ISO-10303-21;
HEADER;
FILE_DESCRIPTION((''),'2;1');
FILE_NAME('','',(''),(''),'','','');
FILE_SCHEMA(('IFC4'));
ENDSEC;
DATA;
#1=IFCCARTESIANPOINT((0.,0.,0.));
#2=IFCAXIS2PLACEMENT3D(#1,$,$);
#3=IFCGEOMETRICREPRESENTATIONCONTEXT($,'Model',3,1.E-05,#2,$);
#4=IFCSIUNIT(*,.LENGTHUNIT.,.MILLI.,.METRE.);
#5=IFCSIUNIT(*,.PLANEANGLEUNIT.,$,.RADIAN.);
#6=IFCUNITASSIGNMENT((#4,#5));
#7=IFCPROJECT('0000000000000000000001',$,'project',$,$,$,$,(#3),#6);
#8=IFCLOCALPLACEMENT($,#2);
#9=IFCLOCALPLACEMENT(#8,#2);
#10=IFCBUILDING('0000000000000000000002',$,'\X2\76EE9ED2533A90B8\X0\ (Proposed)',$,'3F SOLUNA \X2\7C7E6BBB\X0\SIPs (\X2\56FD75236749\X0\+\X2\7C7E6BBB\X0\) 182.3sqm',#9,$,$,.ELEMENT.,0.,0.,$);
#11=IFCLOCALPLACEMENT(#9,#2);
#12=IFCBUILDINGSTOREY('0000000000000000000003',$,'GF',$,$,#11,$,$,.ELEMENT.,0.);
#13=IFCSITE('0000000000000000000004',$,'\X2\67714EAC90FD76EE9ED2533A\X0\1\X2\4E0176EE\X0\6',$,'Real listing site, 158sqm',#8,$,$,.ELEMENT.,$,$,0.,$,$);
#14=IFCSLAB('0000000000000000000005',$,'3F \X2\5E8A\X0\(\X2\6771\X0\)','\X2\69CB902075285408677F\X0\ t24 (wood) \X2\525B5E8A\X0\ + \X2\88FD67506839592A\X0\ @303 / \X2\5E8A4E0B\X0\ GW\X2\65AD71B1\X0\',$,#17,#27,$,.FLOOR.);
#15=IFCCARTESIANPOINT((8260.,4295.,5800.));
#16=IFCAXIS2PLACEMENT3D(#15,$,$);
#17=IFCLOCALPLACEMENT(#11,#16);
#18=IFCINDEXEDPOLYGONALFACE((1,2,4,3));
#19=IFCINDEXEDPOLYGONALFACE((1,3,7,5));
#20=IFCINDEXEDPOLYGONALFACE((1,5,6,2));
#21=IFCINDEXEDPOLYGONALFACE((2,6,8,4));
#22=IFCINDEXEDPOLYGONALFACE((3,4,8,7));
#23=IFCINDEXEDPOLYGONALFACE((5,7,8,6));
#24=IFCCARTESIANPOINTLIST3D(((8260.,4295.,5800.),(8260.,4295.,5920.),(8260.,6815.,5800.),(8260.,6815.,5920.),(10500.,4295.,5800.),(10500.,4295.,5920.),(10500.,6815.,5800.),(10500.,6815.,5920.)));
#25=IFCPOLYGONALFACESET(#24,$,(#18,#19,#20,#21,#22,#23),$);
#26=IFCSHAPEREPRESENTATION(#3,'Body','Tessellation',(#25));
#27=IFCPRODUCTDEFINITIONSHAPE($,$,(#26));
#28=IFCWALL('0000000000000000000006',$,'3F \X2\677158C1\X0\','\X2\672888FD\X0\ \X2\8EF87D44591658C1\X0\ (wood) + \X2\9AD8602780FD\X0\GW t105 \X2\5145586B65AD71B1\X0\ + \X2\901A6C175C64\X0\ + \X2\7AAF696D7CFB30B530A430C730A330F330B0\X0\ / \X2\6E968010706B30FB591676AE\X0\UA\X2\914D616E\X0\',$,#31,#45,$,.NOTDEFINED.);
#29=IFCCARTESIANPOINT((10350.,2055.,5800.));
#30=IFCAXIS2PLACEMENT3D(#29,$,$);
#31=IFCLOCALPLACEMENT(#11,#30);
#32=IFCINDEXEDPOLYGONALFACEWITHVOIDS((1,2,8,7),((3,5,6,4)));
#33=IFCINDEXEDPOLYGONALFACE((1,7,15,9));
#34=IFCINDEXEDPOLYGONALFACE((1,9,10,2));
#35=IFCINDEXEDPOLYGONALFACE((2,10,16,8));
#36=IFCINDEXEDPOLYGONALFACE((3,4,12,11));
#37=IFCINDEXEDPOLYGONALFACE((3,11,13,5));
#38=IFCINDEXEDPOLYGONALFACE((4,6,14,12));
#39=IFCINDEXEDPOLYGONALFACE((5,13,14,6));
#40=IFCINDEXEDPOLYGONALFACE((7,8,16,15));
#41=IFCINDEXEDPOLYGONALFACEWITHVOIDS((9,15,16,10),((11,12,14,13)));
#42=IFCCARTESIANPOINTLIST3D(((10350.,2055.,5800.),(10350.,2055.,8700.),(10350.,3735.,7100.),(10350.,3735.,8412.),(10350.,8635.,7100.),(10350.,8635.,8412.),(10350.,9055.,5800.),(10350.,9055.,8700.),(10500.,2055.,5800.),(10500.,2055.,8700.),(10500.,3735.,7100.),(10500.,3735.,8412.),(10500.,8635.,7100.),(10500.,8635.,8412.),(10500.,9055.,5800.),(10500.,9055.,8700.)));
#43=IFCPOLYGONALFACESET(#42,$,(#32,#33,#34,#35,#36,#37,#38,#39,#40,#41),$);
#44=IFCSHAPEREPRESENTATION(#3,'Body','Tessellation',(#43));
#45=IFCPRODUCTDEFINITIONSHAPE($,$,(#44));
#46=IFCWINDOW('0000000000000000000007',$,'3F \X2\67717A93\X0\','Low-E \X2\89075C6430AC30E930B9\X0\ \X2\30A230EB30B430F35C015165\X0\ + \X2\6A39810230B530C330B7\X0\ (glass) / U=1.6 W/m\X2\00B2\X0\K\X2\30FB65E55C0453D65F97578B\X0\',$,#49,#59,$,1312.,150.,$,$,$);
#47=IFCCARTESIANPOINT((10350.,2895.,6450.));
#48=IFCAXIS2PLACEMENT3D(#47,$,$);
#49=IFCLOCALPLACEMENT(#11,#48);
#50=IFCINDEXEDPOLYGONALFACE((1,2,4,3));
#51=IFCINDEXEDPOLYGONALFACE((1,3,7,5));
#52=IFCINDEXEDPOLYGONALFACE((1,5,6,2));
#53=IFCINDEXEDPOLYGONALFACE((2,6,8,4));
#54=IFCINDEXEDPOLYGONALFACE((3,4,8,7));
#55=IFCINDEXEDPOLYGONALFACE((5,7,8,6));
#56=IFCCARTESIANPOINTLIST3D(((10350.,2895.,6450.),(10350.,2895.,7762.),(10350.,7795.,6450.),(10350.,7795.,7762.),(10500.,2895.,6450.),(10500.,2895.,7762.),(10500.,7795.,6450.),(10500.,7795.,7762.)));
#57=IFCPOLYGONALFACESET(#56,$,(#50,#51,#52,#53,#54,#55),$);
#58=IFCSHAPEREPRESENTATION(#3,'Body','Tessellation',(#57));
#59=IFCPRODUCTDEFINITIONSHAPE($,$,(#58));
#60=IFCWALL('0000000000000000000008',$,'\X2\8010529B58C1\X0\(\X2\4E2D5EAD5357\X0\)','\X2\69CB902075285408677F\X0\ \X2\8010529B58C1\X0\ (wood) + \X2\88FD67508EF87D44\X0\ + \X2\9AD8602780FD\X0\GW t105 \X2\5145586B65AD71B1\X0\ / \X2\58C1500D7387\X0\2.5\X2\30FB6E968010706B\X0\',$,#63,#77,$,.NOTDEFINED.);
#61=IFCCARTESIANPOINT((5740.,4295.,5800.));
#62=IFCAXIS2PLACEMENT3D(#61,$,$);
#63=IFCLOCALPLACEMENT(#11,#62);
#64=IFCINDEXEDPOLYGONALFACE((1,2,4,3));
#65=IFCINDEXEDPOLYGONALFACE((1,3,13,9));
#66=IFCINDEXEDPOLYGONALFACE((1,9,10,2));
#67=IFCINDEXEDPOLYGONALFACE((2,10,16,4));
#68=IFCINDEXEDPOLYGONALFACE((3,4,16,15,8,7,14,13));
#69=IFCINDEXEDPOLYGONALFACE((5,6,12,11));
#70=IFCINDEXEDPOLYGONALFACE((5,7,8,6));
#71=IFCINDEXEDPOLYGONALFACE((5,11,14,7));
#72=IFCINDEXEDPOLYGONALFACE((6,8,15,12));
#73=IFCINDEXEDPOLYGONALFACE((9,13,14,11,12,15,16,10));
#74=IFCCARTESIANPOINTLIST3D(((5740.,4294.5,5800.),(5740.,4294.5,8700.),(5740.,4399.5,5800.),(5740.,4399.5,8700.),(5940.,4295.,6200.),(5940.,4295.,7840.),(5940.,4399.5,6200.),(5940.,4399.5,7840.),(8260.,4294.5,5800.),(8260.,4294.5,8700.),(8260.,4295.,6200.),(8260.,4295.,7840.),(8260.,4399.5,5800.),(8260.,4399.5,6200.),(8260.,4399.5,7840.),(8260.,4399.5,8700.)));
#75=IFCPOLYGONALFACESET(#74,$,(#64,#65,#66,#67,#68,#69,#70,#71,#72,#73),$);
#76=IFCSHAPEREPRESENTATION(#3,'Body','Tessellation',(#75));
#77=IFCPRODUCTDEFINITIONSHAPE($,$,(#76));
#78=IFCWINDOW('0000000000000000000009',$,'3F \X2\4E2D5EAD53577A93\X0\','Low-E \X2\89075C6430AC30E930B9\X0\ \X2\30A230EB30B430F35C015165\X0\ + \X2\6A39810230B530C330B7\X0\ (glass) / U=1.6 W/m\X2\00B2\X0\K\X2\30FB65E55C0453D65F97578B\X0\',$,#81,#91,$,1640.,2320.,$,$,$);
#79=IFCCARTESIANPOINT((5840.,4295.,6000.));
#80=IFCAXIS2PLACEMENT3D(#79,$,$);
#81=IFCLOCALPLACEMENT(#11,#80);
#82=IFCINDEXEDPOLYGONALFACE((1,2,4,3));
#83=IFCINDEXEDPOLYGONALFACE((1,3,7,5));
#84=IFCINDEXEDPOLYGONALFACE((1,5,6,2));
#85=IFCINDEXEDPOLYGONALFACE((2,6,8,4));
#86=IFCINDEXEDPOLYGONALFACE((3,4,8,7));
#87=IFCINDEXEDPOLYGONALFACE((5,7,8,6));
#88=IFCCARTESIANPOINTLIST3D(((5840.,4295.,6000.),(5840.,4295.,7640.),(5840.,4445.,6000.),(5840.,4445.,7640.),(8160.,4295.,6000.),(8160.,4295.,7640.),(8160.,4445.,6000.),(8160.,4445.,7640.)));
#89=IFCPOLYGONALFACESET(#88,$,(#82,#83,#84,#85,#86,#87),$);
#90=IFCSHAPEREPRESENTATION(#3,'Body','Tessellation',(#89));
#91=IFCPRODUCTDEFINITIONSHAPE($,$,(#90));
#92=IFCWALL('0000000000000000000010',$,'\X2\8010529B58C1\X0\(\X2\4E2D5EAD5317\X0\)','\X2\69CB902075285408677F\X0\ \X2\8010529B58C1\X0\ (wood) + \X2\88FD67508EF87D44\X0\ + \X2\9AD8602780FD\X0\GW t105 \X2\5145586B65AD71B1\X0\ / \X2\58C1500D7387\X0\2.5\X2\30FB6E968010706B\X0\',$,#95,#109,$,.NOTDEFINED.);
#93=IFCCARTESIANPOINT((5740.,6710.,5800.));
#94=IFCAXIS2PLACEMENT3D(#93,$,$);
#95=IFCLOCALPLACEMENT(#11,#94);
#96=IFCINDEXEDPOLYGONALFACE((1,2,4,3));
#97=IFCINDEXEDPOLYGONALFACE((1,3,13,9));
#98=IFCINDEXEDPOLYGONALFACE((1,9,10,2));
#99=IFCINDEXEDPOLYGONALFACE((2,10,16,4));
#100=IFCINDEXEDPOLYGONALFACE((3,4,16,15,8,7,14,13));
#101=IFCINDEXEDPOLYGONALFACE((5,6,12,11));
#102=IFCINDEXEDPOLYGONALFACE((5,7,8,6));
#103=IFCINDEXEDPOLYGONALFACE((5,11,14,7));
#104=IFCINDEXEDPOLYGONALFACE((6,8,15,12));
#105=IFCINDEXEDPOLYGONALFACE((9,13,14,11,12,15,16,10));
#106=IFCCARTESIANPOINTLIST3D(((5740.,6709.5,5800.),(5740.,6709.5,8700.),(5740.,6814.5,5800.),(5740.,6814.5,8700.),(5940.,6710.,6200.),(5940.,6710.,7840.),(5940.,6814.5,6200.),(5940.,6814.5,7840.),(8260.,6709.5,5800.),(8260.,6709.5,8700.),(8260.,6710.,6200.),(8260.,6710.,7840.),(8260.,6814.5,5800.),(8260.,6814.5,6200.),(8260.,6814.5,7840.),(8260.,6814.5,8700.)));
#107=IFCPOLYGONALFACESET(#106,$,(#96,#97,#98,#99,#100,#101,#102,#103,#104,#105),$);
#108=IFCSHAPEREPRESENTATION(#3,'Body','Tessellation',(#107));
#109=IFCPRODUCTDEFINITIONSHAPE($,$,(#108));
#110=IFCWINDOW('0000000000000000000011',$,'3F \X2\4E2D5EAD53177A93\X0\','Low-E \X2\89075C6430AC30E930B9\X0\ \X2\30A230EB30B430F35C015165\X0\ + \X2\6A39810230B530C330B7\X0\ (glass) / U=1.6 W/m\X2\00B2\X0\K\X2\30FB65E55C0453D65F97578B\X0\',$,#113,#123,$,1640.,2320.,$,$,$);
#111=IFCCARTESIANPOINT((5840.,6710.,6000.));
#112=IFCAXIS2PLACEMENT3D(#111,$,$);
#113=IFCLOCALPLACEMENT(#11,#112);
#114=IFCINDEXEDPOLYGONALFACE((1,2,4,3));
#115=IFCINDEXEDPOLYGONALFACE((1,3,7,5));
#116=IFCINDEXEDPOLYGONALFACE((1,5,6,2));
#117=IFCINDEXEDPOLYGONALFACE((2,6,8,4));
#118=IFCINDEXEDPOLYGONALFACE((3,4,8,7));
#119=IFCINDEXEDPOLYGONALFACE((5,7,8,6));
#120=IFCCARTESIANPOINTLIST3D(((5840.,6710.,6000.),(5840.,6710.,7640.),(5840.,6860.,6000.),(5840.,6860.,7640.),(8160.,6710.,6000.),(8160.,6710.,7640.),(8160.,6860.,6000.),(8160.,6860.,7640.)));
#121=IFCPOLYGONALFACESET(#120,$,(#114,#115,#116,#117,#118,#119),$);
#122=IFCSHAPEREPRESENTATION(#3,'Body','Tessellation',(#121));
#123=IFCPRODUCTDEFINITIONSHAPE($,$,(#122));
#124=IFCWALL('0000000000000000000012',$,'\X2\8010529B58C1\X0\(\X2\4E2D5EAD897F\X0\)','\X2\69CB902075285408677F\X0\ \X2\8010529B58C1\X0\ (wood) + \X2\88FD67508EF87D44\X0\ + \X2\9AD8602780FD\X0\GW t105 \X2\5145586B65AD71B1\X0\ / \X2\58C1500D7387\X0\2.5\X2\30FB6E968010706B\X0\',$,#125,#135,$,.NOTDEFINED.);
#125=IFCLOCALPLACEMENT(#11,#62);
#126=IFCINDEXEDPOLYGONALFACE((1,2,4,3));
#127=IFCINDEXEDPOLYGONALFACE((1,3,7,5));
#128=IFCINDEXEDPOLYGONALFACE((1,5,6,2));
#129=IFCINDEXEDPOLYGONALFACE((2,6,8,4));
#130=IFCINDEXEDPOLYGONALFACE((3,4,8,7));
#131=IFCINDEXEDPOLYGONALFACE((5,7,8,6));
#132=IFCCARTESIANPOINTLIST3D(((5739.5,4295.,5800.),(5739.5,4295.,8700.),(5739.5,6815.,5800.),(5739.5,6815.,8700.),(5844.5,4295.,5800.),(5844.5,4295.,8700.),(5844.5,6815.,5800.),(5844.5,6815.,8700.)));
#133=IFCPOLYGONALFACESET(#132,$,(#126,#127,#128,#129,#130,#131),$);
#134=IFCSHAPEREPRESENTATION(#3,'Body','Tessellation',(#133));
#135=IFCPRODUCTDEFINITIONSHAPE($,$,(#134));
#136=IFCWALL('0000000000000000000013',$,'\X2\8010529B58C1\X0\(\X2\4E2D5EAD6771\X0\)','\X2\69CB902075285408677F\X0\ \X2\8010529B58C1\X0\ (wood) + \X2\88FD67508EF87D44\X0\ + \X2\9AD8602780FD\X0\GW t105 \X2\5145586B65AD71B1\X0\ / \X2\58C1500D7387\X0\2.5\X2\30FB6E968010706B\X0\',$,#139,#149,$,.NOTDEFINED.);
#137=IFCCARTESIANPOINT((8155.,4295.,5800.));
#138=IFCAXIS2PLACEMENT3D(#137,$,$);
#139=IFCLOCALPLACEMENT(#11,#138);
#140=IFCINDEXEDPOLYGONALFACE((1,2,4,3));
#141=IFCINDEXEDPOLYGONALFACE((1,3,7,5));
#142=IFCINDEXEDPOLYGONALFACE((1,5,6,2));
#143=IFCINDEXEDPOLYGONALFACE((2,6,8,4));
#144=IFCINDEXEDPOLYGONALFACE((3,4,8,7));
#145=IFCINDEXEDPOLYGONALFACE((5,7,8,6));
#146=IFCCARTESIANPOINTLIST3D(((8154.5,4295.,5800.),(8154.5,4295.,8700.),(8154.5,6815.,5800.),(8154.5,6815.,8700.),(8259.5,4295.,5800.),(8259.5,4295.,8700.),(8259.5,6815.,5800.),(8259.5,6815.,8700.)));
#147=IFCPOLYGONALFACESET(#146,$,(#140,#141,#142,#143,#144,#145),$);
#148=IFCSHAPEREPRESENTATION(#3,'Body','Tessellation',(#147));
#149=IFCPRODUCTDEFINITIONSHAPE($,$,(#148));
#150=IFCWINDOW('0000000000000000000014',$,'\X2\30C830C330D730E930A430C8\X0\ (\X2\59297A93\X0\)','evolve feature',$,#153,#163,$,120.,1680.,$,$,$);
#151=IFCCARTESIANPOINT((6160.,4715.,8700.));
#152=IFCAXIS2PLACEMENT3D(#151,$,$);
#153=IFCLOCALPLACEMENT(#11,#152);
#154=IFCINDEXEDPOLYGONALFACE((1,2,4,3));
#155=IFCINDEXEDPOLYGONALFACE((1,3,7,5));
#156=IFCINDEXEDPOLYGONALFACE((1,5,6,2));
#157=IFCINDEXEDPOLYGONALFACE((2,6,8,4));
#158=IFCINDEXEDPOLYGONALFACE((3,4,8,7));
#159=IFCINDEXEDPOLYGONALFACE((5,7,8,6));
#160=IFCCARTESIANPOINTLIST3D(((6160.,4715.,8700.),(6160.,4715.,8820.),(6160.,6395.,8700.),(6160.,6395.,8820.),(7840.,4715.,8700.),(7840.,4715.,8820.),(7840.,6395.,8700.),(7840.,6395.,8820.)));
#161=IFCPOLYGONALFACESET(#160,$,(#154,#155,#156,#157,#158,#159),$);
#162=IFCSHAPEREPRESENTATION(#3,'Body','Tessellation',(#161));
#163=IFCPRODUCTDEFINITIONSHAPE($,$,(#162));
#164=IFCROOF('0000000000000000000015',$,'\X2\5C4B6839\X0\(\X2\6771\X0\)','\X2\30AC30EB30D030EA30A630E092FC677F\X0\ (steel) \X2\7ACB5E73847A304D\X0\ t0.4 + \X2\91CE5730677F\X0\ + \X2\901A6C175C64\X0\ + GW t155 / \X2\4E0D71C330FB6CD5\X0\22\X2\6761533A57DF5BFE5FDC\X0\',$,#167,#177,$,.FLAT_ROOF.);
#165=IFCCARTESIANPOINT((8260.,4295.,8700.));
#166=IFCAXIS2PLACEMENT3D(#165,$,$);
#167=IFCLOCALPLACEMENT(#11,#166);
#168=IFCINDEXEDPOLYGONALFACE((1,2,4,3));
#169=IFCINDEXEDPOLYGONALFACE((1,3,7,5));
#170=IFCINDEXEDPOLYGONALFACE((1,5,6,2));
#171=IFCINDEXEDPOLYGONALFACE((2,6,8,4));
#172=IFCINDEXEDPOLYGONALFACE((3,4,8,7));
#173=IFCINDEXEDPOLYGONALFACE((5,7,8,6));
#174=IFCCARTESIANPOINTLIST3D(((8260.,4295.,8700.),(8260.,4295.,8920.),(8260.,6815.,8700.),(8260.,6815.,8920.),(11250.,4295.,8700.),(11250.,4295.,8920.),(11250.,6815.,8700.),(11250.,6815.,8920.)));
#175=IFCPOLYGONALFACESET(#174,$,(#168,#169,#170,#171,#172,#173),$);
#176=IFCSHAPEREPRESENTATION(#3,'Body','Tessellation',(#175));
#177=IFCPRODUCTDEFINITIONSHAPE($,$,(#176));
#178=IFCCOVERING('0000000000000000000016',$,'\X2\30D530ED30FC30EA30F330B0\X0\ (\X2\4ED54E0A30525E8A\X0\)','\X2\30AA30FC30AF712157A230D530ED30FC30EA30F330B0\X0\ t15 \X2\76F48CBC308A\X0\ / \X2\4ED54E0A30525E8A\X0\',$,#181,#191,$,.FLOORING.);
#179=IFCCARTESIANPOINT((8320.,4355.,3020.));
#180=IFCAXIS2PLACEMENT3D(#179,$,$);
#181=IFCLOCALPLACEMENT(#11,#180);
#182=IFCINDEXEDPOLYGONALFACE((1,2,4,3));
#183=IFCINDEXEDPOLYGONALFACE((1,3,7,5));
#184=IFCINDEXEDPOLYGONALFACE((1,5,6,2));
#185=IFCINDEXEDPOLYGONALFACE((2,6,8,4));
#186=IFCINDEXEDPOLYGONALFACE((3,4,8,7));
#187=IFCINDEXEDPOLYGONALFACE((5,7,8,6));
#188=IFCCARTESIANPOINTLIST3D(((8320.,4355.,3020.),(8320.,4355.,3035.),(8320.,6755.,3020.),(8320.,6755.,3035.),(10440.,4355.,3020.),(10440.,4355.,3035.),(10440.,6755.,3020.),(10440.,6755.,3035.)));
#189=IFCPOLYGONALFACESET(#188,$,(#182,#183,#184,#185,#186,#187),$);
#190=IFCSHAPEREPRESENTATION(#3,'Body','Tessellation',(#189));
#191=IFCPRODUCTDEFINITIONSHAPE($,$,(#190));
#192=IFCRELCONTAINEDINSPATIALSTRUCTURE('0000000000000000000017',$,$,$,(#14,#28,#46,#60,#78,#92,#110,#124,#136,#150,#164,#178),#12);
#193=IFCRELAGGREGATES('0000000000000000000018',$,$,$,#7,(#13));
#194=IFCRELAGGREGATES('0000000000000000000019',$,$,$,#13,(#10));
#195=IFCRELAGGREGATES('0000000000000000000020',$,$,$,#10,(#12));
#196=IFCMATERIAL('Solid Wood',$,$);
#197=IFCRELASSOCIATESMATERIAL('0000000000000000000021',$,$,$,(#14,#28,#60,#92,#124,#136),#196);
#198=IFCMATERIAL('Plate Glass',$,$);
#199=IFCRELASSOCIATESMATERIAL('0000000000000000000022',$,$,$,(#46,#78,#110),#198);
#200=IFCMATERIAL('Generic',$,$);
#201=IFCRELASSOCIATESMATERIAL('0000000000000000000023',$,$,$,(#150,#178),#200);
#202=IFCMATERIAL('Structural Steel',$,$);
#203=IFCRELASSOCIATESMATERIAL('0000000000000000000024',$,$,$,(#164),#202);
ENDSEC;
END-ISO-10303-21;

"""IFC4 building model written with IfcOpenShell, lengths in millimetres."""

from ifc_helpers import new_model, si_unit, frame, frame_2d, origin, place, context, project, spatial, rectangle, extrude, material, element, fill, save


model = new_model("IFC4")

# Units and contexts
model_context = context("Model", 3, precision=1e-05, world=origin())
ifc_project = project(units=[si_unit("LENGTHUNIT", "METRE", prefix="MILLI"), si_unit("PLANEANGLEUNIT", "RADIAN")], contexts=[model_context])

# Site, building, storey
site_placement = place(None, origin())
site = spatial("IfcSite", under=ifc_project, at=site_placement, Name="東京都目黒区1丁目6", ObjectType="Real listing site, 158sqm", CompositionType="ELEMENT", RefElevation=0.0)
building_placement = place(site_placement, origin())
building = spatial("IfcBuilding", under=site, at=building_placement, Name="目黒区邸 (Proposed)", ObjectType="3F SOLUNA 籾殻SIPs (国産杉+籾殻) 182.3sqm", CompositionType="ELEMENT", ElevationOfRefHeight=0.0, ElevationOfTerrain=0.0)
storey_placement = place(building_placement, origin())
storey = spatial("IfcBuildingStorey", under=building, at=storey_placement, Name="GF", CompositionType="ELEMENT", Elevation=0.0)

# Slab
ifc_material_1 = material(Name="Solid Wood")
slab_placement = place(storey_placement, frame((8260.0, 4295.0, 5800.0)))
element("IfcSlab", 1, at=slab_placement, inside=storey, material=ifc_material_1, Name="3F 床(東)", Description="構造用合板 t24 (wood) 剛床 + 製材根太 @303 / 床下 GW断熱", PredefinedType="FLOOR", context=model_context, shape_type="SweptSolid", body=[
    extrude(rectangle(XDim=2240.0, YDim=2520.0, at=frame_2d((1120.0, 1260.0))), frame((8260.0, 4295.0, 5800.0)), (0.0, 0.0, 1.0), 120.0),
])

# Walls, openings, windows
wall_1_placement = place(storey_placement, frame((10350.0, 2055.0, 5800.0)))
wall_1 = element("IfcWall", 2, at=wall_1_placement, inside=storey, material=ifc_material_1, Name="3F 東壁", Description="木製 軸組外壁 (wood) + 高性能GW t105 充填断熱 + 通気層 + 窯業系サイディング / 準耐火・外皮UA配慮", PredefinedType="NOTDEFINED", context=model_context, shape_type="SweptSolid", body=[
    extrude(rectangle(XDim=150.0, YDim=7000.0, at=frame_2d((75.0, 3500.0))), frame((10350.0, 2055.0, 5800.0)), (0.0, 0.0, 1.0), 2900.0),
])
opening_1_placement = place(storey_placement, frame((10350.0, 2895.0, 6450.0)))
opening_1 = element("IfcOpeningElement", 3, at=opening_1_placement, cuts=wall_1, PredefinedType="NOTDEFINED", context=model_context, shape_type="SweptSolid", body=[
    extrude(rectangle(XDim=150.0, YDim=4900.0, at=frame_2d((75.0, 2450.0))), frame((10350.0, 2895.0, 6450.0)), (0.0, 0.0, 1.0), 1312.0),
])
ifc_material_2 = material(Name="Plate Glass")
window_1_placement = place(storey_placement, frame((10350.0, 2895.0, 6450.0)))
window_1 = element("IfcWindow", 4, at=window_1_placement, inside=storey, material=ifc_material_2, Name="3F 東窓", Description="Low-E 複層ガラス アルゴン封入 + 樹脂サッシ (glass) / U=1.6 W/m²K・日射取得型", OverallHeight=1312.0, OverallWidth=150.0, context=model_context, shape_type="SweptSolid", body=[
    extrude(rectangle(XDim=150.0, YDim=4900.0, at=frame_2d((75.0, 2450.0))), frame((10350.0, 2895.0, 6450.0)), (0.0, 0.0, 1.0), 1312.0),
])
fill(opening_1, window_1)
wall_2_placement = place(storey_placement, frame((5740.0, 4295.0, 5800.0)))
wall_2 = element("IfcWall", 5, at=wall_2_placement, inside=storey, material=ifc_material_1, Name="耐力壁(中庭南)", Description="構造用合板 耐力壁 (wood) + 製材軸組 + 高性能GW t105 充填断熱 / 壁倍率2.5・準耐火", PredefinedType="NOTDEFINED", context=model_context, shape_type="SweptSolid", body=[
    extrude(rectangle(XDim=2520.0, YDim=105.0, at=frame_2d((1260.0, 52.0))), frame((5740.0, 4295.0, 5800.0)), (0.0, 0.0, 1.0), 2900.0),
])
opening_2_placement = place(storey_placement, frame((5840.0, 4295.0, 6000.0)))
opening_2 = element("IfcOpeningElement", 6, at=opening_2_placement, cuts=wall_2, PredefinedType="NOTDEFINED", context=model_context, shape_type="SweptSolid", body=[
    extrude(rectangle(XDim=2320.0, YDim=150.0, at=frame_2d((1160.0, 75.0))), frame((5840.0, 4295.0, 6000.0)), (0.0, 0.0, 1.0), 1640.0),
])
window_2_placement = place(storey_placement, frame((5840.0, 4295.0, 6000.0)))
window_2 = element("IfcWindow", 7, at=window_2_placement, inside=storey, material=ifc_material_2, Name="3F 中庭南窓", Description="Low-E 複層ガラス アルゴン封入 + 樹脂サッシ (glass) / U=1.6 W/m²K・日射取得型", OverallHeight=1640.0, OverallWidth=2320.0, context=model_context, shape_type="SweptSolid", body=[
    extrude(rectangle(XDim=2320.0, YDim=150.0, at=frame_2d((1160.0, 75.0))), frame((5840.0, 4295.0, 6000.0)), (0.0, 0.0, 1.0), 1640.0),
])
fill(opening_2, window_2)
wall_3_placement = place(storey_placement, frame((5740.0, 6710.0, 5800.0)))
wall_3 = element("IfcWall", 8, at=wall_3_placement, inside=storey, material=ifc_material_1, Name="耐力壁(中庭北)", Description="構造用合板 耐力壁 (wood) + 製材軸組 + 高性能GW t105 充填断熱 / 壁倍率2.5・準耐火", PredefinedType="NOTDEFINED", context=model_context, shape_type="SweptSolid", body=[
    extrude(rectangle(XDim=2520.0, YDim=105.0, at=frame_2d((1260.0, 52.0))), frame((5740.0, 6710.0, 5800.0)), (0.0, 0.0, 1.0), 2900.0),
])
opening_3_placement = place(storey_placement, frame((5840.0, 6710.0, 6000.0)))
opening_3 = element("IfcOpeningElement", 9, at=opening_3_placement, cuts=wall_3, PredefinedType="NOTDEFINED", context=model_context, shape_type="SweptSolid", body=[
    extrude(rectangle(XDim=2320.0, YDim=150.0, at=frame_2d((1160.0, 75.0))), frame((5840.0, 6710.0, 6000.0)), (0.0, 0.0, 1.0), 1640.0),
])
window_3_placement = place(storey_placement, frame((5840.0, 6710.0, 6000.0)))
window_3 = element("IfcWindow", 10, at=window_3_placement, inside=storey, material=ifc_material_2, Name="3F 中庭北窓", Description="Low-E 複層ガラス アルゴン封入 + 樹脂サッシ (glass) / U=1.6 W/m²K・日射取得型", OverallHeight=1640.0, OverallWidth=2320.0, context=model_context, shape_type="SweptSolid", body=[
    extrude(rectangle(XDim=2320.0, YDim=150.0, at=frame_2d((1160.0, 75.0))), frame((5840.0, 6710.0, 6000.0)), (0.0, 0.0, 1.0), 1640.0),
])
fill(opening_3, window_3)

# Walls
wall_4_placement = place(storey_placement, frame((5740.0, 4295.0, 5800.0)))
element("IfcWall", 11, at=wall_4_placement, inside=storey, material=ifc_material_1, Name="耐力壁(中庭西)", Description="構造用合板 耐力壁 (wood) + 製材軸組 + 高性能GW t105 充填断熱 / 壁倍率2.5・準耐火", PredefinedType="NOTDEFINED", context=model_context, shape_type="SweptSolid", body=[
    extrude(rectangle(XDim=105.0, YDim=2520.0, at=frame_2d((52.0, 1260.0))), frame((5740.0, 4295.0, 5800.0)), (0.0, 0.0, 1.0), 2900.0),
])
wall_5_placement = place(storey_placement, frame((8155.0, 4295.0, 5800.0)))
element("IfcWall", 12, at=wall_5_placement, inside=storey, material=ifc_material_1, Name="耐力壁(中庭東)", Description="構造用合板 耐力壁 (wood) + 製材軸組 + 高性能GW t105 充填断熱 / 壁倍率2.5・準耐火", PredefinedType="NOTDEFINED", context=model_context, shape_type="SweptSolid", body=[
    extrude(rectangle(XDim=105.0, YDim=2520.0, at=frame_2d((52.0, 1260.0))), frame((8155.0, 4295.0, 5800.0)), (0.0, 0.0, 1.0), 2900.0),
])

# Window
ifc_material_3 = material(Name="Generic")
window_4_placement = place(storey_placement, frame((6160.0, 4715.0, 8700.0)))
element("IfcWindow", 13, at=window_4_placement, inside=storey, material=ifc_material_3, Name="トップライト (天窓)", Description="evolve feature", OverallHeight=120.0, OverallWidth=1680.0, context=model_context, shape_type="SweptSolid", body=[
    extrude(rectangle(XDim=1680.0, YDim=1680.0, at=frame_2d((840.0, 840.0))), frame((6160.0, 4715.0, 8700.0)), (0.0, 0.0, 1.0), 120.0),
])

# Roof
ifc_material_4 = material(Name="Structural Steel")
for number, where, name in (
    (14, (8260.0, 4295.0, 8700.0), "屋根(東)"),
):
    element("IfcRoof", number, at=place(storey_placement, frame(where)), inside=storey, material=ifc_material_4, Name=name, Description="ガルバリウム鋼板 (steel) 立平葺き t0.4 + 野地板 + 通気層 + GW t155 / 不燃・法22条区域対応", PredefinedType="FLAT_ROOF", context=model_context, shape_type="SweptSolid", body=[
        extrude(rectangle(XDim=2990.0, YDim=2520.0, at=frame_2d((1495.0, 1260.0))), frame((8260.0, 4295.0, 8700.0)), (0.0, 0.0, 1.0), 220.0),
    ])

# Covering
covering_1_placement = place(storey_placement, frame((8320.0, 4355.0, 3020.0)))
element("IfcCovering", 15, at=covering_1_placement, inside=storey, material=ifc_material_3, Name="フローリング (仕上げ床)", Description="オーク無垢フローリング t15 直貼り / 仕上げ床", PredefinedType="FLOORING", context=model_context, shape_type="SweptSolid", body=[
    extrude(rectangle(XDim=2120.0, YDim=2400.0, at=frame_2d((1060.0, 1200.0))), frame((8320.0, 4355.0, 3020.0)), (0.0, 0.0, 1.0), 15.0),
])

save(model, "model.ifc")
